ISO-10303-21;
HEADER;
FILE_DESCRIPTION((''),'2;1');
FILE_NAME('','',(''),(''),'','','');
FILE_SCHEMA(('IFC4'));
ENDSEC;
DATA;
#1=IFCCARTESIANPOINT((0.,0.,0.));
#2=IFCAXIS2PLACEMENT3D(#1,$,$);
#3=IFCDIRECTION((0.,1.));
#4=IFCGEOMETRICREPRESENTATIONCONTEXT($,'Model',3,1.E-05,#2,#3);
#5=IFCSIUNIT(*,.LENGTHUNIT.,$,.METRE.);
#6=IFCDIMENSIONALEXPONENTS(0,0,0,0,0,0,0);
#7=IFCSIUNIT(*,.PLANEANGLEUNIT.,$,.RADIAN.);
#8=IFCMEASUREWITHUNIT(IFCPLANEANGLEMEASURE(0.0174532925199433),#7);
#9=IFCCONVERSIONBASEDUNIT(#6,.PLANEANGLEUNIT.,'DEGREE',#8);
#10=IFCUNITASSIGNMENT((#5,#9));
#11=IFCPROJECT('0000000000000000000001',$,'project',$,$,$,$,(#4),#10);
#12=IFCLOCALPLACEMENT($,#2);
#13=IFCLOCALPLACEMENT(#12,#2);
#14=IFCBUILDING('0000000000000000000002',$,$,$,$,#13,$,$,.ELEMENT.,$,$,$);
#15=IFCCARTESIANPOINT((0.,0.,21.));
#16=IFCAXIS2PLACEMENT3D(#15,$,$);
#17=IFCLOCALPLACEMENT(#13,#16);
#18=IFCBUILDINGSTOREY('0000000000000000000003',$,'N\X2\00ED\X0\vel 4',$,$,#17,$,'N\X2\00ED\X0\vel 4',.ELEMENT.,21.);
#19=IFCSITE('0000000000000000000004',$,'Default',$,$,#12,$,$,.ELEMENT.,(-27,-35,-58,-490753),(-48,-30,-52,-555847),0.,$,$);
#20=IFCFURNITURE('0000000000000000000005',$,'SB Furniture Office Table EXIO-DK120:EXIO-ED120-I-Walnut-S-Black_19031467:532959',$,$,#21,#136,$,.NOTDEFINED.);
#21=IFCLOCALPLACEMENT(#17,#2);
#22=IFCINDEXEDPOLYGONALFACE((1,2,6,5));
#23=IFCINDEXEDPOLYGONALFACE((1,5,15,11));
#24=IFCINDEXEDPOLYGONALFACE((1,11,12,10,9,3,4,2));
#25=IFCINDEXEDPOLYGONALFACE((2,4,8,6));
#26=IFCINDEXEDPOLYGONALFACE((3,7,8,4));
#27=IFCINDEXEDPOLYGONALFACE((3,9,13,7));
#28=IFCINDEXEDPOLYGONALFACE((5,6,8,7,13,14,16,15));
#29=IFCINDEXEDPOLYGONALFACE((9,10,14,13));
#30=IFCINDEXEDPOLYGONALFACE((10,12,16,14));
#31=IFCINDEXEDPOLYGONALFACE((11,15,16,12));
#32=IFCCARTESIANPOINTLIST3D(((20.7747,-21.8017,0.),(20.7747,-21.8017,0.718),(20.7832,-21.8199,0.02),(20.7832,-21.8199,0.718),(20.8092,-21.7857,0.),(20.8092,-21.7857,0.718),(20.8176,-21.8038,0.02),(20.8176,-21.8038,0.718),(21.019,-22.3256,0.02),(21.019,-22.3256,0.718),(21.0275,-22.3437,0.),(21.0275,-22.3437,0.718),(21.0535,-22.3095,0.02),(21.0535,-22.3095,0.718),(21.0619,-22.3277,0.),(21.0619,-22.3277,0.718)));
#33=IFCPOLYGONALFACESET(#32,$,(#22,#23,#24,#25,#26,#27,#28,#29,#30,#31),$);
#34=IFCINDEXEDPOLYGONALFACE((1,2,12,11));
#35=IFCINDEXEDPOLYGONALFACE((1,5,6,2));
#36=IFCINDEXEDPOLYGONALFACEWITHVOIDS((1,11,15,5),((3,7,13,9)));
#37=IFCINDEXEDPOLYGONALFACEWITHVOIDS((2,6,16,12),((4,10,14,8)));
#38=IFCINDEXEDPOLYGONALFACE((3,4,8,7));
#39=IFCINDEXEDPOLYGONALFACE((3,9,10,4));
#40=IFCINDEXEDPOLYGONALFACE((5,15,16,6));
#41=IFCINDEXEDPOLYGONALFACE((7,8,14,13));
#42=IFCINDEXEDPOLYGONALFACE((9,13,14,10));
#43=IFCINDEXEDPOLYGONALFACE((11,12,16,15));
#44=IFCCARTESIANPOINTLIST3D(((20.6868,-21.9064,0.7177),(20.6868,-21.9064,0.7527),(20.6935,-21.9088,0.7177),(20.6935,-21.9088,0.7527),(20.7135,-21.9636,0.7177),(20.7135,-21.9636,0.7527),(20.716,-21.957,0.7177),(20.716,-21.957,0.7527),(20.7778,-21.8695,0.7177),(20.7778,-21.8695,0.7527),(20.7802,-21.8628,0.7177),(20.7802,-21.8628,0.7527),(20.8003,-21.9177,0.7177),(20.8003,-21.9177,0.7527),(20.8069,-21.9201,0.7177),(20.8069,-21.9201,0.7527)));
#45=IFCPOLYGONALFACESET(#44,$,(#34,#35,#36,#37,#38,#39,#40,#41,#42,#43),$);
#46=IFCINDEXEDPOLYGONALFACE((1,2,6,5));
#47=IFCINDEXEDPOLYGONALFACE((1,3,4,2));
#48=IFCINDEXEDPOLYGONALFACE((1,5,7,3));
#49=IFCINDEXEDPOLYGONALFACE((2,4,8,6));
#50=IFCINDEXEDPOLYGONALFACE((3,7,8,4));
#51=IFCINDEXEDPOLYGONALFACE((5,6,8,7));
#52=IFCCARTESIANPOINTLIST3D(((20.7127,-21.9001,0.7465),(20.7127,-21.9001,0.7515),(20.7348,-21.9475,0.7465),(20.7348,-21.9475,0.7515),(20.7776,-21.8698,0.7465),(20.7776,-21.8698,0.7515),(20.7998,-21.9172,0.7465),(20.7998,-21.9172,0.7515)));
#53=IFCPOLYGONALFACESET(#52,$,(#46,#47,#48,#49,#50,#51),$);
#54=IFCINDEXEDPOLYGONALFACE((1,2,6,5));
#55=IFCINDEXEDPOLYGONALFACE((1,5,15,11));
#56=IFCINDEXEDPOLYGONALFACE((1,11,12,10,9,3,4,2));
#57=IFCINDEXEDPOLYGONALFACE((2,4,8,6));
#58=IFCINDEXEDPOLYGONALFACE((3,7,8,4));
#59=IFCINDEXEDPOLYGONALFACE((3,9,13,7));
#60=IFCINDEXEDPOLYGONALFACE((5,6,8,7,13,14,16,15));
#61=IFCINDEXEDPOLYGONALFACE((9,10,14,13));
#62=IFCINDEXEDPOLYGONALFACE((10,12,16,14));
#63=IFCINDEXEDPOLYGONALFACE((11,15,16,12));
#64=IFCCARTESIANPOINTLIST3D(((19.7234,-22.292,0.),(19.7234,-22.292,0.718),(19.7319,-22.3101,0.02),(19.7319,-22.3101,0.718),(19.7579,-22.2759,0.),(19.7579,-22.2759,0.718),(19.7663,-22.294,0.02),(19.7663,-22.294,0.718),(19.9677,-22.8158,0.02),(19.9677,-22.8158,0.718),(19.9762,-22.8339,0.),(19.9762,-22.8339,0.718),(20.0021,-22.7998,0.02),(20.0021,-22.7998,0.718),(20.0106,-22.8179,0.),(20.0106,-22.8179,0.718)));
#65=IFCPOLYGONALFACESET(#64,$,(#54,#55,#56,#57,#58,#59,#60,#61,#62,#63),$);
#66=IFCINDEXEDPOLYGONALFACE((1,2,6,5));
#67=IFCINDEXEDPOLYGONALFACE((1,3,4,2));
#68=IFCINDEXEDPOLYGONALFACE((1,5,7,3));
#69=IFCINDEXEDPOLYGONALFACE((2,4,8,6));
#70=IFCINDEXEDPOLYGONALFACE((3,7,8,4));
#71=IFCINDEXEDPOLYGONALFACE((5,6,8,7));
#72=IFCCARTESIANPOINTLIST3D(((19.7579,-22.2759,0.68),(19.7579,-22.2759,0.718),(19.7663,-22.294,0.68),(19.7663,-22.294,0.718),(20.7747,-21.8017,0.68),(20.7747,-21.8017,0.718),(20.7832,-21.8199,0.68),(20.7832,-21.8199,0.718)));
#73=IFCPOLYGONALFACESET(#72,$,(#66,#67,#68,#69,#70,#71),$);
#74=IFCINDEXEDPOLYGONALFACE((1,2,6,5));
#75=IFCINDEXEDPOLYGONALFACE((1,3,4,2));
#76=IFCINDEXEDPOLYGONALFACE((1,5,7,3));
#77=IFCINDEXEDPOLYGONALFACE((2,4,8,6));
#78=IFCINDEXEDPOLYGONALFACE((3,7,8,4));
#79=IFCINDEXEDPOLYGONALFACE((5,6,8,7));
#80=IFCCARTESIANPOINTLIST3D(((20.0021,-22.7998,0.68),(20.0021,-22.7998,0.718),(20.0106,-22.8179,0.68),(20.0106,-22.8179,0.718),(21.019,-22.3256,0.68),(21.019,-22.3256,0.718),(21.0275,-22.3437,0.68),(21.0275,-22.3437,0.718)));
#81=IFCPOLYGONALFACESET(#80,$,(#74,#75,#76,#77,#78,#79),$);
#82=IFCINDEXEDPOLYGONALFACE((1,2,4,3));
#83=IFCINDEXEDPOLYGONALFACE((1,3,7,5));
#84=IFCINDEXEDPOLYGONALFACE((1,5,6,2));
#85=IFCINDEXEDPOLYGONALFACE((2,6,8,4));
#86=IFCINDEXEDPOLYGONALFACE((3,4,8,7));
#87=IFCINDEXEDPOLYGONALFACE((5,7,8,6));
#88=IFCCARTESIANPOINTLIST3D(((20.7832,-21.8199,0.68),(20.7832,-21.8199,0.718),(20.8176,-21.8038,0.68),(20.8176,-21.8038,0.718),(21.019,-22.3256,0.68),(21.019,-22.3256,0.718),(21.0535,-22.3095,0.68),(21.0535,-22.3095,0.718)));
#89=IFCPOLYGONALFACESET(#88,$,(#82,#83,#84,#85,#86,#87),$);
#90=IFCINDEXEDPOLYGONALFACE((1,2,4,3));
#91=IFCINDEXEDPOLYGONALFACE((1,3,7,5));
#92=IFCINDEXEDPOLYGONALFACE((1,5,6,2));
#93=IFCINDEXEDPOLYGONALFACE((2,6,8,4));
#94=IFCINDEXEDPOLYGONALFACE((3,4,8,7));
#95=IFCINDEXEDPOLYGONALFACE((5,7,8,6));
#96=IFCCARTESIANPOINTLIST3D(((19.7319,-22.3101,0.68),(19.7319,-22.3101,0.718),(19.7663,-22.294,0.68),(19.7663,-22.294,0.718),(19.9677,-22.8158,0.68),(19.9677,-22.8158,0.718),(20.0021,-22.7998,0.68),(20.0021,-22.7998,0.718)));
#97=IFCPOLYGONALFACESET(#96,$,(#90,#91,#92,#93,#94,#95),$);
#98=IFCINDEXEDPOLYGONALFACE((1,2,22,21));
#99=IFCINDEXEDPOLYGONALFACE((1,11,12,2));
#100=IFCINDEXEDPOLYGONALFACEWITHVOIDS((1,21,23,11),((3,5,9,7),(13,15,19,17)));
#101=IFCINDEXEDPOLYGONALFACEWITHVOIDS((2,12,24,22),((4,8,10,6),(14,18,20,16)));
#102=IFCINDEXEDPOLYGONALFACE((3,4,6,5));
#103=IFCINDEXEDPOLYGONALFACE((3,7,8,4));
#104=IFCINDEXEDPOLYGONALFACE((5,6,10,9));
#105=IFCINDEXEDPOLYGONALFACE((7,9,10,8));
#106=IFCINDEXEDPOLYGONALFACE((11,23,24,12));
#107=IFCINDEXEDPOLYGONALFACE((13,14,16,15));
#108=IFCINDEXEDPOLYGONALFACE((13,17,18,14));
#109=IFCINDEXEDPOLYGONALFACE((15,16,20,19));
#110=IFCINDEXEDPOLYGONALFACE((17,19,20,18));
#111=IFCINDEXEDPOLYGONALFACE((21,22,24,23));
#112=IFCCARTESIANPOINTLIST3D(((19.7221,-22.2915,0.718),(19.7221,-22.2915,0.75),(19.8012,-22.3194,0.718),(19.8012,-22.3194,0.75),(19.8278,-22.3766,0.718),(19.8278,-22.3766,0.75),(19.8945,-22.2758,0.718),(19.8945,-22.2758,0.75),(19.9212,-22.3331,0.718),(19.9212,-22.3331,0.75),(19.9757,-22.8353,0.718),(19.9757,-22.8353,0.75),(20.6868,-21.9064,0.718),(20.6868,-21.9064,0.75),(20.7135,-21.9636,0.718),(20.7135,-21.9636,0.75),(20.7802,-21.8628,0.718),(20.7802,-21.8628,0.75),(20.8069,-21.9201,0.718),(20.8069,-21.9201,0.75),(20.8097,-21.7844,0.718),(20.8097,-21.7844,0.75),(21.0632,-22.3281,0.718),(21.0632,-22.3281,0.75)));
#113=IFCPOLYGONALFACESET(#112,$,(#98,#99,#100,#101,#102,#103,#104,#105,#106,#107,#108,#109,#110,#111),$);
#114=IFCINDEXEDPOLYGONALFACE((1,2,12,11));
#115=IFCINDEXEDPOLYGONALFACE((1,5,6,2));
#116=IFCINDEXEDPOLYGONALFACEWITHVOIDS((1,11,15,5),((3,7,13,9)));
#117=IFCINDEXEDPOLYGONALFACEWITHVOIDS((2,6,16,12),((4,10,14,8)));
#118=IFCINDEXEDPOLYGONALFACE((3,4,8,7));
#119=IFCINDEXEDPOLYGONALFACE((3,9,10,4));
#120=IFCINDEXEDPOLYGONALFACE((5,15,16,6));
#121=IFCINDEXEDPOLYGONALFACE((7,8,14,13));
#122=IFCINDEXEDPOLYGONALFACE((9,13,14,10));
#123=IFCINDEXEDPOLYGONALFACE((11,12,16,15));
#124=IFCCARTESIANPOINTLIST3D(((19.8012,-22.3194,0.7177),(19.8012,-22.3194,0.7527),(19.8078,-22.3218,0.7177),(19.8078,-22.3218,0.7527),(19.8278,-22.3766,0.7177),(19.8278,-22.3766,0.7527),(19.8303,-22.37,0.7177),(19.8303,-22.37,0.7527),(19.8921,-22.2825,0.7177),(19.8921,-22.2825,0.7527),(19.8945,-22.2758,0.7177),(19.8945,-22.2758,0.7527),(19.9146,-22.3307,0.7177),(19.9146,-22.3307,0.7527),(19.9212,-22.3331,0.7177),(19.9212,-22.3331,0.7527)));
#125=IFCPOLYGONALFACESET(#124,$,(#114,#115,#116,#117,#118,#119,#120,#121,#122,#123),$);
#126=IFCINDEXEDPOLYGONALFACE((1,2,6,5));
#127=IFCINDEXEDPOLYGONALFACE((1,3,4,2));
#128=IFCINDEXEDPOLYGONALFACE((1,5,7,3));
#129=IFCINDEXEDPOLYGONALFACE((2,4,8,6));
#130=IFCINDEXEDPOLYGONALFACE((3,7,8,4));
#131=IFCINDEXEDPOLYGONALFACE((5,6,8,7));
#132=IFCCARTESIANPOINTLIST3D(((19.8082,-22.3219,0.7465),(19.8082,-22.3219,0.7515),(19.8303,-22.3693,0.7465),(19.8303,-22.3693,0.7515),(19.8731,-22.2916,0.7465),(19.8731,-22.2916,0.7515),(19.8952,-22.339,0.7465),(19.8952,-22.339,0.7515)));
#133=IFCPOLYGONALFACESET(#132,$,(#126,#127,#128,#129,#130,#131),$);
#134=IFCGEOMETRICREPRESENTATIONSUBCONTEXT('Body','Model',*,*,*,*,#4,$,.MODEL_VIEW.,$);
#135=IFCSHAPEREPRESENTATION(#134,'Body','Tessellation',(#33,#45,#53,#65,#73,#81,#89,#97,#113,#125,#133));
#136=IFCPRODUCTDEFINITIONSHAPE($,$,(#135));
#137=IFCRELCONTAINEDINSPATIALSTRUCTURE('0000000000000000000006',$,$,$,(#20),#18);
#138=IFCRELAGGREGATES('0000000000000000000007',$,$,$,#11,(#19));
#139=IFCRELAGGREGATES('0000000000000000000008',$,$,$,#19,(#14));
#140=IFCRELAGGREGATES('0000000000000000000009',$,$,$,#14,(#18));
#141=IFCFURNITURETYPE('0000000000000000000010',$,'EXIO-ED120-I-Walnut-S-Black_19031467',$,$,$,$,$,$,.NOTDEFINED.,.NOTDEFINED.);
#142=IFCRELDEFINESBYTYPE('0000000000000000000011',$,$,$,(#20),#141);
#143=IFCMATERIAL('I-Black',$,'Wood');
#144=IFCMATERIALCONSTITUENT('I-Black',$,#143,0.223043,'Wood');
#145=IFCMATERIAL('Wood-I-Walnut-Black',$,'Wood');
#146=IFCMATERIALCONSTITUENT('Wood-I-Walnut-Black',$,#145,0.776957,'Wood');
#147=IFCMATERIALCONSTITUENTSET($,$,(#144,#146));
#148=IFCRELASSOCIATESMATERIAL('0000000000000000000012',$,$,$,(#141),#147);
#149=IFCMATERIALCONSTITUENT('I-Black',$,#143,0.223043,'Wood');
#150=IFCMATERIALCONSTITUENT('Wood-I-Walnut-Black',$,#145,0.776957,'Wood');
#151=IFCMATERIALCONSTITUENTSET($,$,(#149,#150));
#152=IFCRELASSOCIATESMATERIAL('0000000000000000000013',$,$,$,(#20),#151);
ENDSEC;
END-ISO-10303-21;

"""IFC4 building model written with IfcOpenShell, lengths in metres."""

from ifc_helpers import new_model, entity, si_unit, converted_unit, direction, frame, frame_2d, origin, origin_2d_with_axis, place, context, subcontext, project, spatial, polyline, rectangle, outline, extrude, source, transform, mapped, material, constituent, constituent_set, type_object, type_shapes, element, save


model = new_model("IFC4")

# Units and contexts
model_context = context("Model", 3, precision=1e-05, world=origin(), true_north=direction((0.0, 1.0)))
body_context = subcontext(model_context, "Body", "Model", "MODEL_VIEW")
ifc_project = project(units=[si_unit("LENGTHUNIT", "METRE"), converted_unit("PLANEANGLEUNIT", "DEGREE", entity("IfcPlaneAngleMeasure", 0.0174532925199433), si_unit("PLANEANGLEUNIT", "RADIAN"), dimensions=[0, 0, 0, 0, 0, 0, 0])], contexts=[model_context])

# Site, building, storey
site_placement = place(None, origin())
site = spatial("IfcSite", under=ifc_project, at=site_placement, Name="Default", CompositionType="ELEMENT", RefLatitude=(-27, -35, -58, -490753), RefLongitude=(-48, -30, -52, -555847), RefElevation=0.0)
building_placement = place(site_placement, origin())
building = spatial("IfcBuilding", under=site, at=building_placement, CompositionType="ELEMENT")
storey_placement = place(building_placement, frame((0.0, 0.0, 21.0)))
storey = spatial("IfcBuildingStorey", under=building, at=storey_placement, Name="Nível 4", LongName="Nível 4", CompositionType="ELEMENT", Elevation=21.0)

# Furniture
ifc_material_1 = material(Name="I-Black", Category="Wood")
ifc_material_2 = material(Name="Wood-I-Walnut-Black", Category="Wood")
ifc_constituent_1 = constituent(ifc_material_1, Name="I-Black", Category="Wood", fraction=0.223043)
ifc_constituent_2 = constituent(ifc_material_2, Name="Wood-I-Walnut-Black", Category="Wood", fraction=0.776957)
ifc_constituent_set_1 = constituent_set(constituents=[ifc_constituent_1, ifc_constituent_2])
furniture_type = type_object("IfcFurnitureType", Name="EXIO-ED120-I-Walnut-S-Black_19031467", AssemblyPlace="NOTDEFINED", PredefinedType="NOTDEFINED", material=ifc_constituent_set_1)
shared_shape_1 = source(origin(), body_context, "Body", "SweptSolid", [
    extrude(outline(polyline([(-0.354, -0.279), (-0.354, -0.299), (0.364, -0.299), (0.364, 0.299), (-0.354, 0.299), (-0.354, 0.279), (0.344, 0.279), (0.344, -0.279), (-0.354, -0.279)])), frame((0.561, 0.0, 0.364), z_axis=(-1.0, 0.0, 0.0), x_axis=(0.0, 0.0, -1.0)), (0.0, 0.0, -1.0), 0.038),
    extrude(outline(polyline([(-0.0316, -0.0515), (0.0316, -0.0515), (0.0316, 0.0515), (-0.0316, 0.0515), (-0.0316, -0.0515)]), holes=[polyline([(0.0266, -0.0465), (-0.0266, -0.0465), (-0.0266, 0.0465), (0.0266, 0.0465), (0.0266, -0.0465)])]), frame((0.4886, 0.2097, 0.7177), z_axis=(0.0, 0.0, 1.0), x_axis=(0.0, -1.0, 0.0)), (0.0, 0.0, 1.0), 0.035),
    extrude(rectangle(XDim=0.0717, YDim=0.0523, at=origin_2d_with_axis()), frame((0.499, 0.2099, 0.7465), z_axis=(0.0, 0.0, 1.0), x_axis=(-1.0, 0.0, 0.0)), (0.0, 0.0, 1.0), 0.005),
    extrude(outline(polyline([(-0.354, -0.279), (-0.354, -0.299), (0.364, -0.299), (0.364, 0.299), (-0.354, 0.299), (-0.354, 0.279), (0.344, 0.279), (0.344, -0.279), (-0.354, -0.279)])), frame((-0.599, 0.0, 0.364), z_axis=(-1.0, 0.0, 0.0), x_axis=(0.0, 0.0, -1.0)), (0.0, 0.0, -1.0), 0.038),
    extrude(rectangle(XDim=1.122, YDim=0.02, at=frame_2d((0.0, 0.0), x_axis=(1.0, 0.0))), frame((0.0, 0.289, 0.68), z_axis=(0.0, 0.0, 1.0), x_axis=(-1.0, 0.0, 0.0)), (0.0, 0.0, 1.0), 0.038),
    extrude(rectangle(XDim=1.122, YDim=0.02, at=origin_2d_with_axis()), frame((0.0, -0.289, 0.68), z_axis=(0.0, 0.0, 1.0), x_axis=(-1.0, 0.0, 0.0)), (0.0, 0.0, 1.0), 0.038),
    extrude(rectangle(XDim=0.038, YDim=0.558, at=frame_2d((0.0, 0.0), x_axis=(1.0, 0.0))), frame((0.58, 0.0, 0.68), z_axis=(0.0, 0.0, 1.0), x_axis=(-1.0, 0.0, 0.0)), (0.0, 0.0, 1.0), 0.038),
    extrude(rectangle(XDim=0.038, YDim=0.558, at=origin_2d_with_axis()), frame((-0.58, 0.0, 0.68), z_axis=(0.0, 0.0, 1.0), x_axis=(-1.0, 0.0, 0.0)), (0.0, 0.0, 1.0), 0.038),
    extrude(outline(polyline([(-0.6, -0.3), (0.6, -0.3), (0.6, 0.3), (-0.6, 0.3), (-0.6, -0.3)]), holes=[polyline([(0.4371, -0.2413), (0.4371, -0.1782), (0.5401, -0.1782), (0.5401, -0.2413), (0.4371, -0.2413)]), polyline([(-0.5401, -0.2413), (-0.5401, -0.1782), (-0.4371, -0.1782), (-0.4371, -0.2413), (-0.5401, -0.2413)])]), frame((0.0, 0.0, 0.718), z_axis=(0.0, 0.0, 1.0), x_axis=(-1.0, 0.0, 0.0)), (0.0, 0.0, 1.0), 0.032),
    extrude(outline(polyline([(-0.0316, -0.0515), (0.0316, -0.0515), (0.0316, 0.0515), (-0.0316, 0.0515), (-0.0316, -0.0515)]), holes=[polyline([(0.0266, -0.0465), (-0.0266, -0.0465), (-0.0266, 0.0465), (0.0266, 0.0465), (0.0266, -0.0465)])]), frame((-0.4886, 0.2097, 0.7177), z_axis=(0.0, 0.0, 1.0), x_axis=(0.0, 1.0, 0.0)), (0.0, 0.0, 1.0), 0.035),
    extrude(rectangle(XDim=0.0523, YDim=0.0717, at=origin_2d_with_axis()), frame((-0.499, 0.2099, 0.7465), z_axis=(0.0, 0.0, 1.0), x_axis=(0.0, -1.0, 0.0)), (0.0, 0.0, 1.0), 0.005),
])
type_shapes(furniture_type, [shared_shape_1])
ifc_constituent_3 = constituent(ifc_material_1, Name="I-Black", Category="Wood", fraction=0.223043)
ifc_constituent_4 = constituent(ifc_material_2, Name="Wood-I-Walnut-Black", Category="Wood", fraction=0.776957)
ifc_constituent_set_2 = constituent_set(constituents=[ifc_constituent_3, ifc_constituent_4])
furniture_1_placement = place(storey_placement, frame((20.3927, -22.3098, 0.0), z_axis=(0.0, 0.0, 1.0), x_axis=(0.906308, 0.422618, 0.0)))
element("IfcFurniture", 1, at=furniture_1_placement, inside=storey, type_object=furniture_type, material=ifc_constituent_set_2, Name="SB Furniture Office Table EXIO-DK120:EXIO-ED120-I-Walnut-S-Black_19031467:532959", PredefinedType="NOTDEFINED", context=body_context, shape_type="MappedRepresentation", body=[
    mapped(shared_shape_1, transform((0.0, 0.0, 0.0), scale=1.0)),
])

save(model, "model.ifc")
